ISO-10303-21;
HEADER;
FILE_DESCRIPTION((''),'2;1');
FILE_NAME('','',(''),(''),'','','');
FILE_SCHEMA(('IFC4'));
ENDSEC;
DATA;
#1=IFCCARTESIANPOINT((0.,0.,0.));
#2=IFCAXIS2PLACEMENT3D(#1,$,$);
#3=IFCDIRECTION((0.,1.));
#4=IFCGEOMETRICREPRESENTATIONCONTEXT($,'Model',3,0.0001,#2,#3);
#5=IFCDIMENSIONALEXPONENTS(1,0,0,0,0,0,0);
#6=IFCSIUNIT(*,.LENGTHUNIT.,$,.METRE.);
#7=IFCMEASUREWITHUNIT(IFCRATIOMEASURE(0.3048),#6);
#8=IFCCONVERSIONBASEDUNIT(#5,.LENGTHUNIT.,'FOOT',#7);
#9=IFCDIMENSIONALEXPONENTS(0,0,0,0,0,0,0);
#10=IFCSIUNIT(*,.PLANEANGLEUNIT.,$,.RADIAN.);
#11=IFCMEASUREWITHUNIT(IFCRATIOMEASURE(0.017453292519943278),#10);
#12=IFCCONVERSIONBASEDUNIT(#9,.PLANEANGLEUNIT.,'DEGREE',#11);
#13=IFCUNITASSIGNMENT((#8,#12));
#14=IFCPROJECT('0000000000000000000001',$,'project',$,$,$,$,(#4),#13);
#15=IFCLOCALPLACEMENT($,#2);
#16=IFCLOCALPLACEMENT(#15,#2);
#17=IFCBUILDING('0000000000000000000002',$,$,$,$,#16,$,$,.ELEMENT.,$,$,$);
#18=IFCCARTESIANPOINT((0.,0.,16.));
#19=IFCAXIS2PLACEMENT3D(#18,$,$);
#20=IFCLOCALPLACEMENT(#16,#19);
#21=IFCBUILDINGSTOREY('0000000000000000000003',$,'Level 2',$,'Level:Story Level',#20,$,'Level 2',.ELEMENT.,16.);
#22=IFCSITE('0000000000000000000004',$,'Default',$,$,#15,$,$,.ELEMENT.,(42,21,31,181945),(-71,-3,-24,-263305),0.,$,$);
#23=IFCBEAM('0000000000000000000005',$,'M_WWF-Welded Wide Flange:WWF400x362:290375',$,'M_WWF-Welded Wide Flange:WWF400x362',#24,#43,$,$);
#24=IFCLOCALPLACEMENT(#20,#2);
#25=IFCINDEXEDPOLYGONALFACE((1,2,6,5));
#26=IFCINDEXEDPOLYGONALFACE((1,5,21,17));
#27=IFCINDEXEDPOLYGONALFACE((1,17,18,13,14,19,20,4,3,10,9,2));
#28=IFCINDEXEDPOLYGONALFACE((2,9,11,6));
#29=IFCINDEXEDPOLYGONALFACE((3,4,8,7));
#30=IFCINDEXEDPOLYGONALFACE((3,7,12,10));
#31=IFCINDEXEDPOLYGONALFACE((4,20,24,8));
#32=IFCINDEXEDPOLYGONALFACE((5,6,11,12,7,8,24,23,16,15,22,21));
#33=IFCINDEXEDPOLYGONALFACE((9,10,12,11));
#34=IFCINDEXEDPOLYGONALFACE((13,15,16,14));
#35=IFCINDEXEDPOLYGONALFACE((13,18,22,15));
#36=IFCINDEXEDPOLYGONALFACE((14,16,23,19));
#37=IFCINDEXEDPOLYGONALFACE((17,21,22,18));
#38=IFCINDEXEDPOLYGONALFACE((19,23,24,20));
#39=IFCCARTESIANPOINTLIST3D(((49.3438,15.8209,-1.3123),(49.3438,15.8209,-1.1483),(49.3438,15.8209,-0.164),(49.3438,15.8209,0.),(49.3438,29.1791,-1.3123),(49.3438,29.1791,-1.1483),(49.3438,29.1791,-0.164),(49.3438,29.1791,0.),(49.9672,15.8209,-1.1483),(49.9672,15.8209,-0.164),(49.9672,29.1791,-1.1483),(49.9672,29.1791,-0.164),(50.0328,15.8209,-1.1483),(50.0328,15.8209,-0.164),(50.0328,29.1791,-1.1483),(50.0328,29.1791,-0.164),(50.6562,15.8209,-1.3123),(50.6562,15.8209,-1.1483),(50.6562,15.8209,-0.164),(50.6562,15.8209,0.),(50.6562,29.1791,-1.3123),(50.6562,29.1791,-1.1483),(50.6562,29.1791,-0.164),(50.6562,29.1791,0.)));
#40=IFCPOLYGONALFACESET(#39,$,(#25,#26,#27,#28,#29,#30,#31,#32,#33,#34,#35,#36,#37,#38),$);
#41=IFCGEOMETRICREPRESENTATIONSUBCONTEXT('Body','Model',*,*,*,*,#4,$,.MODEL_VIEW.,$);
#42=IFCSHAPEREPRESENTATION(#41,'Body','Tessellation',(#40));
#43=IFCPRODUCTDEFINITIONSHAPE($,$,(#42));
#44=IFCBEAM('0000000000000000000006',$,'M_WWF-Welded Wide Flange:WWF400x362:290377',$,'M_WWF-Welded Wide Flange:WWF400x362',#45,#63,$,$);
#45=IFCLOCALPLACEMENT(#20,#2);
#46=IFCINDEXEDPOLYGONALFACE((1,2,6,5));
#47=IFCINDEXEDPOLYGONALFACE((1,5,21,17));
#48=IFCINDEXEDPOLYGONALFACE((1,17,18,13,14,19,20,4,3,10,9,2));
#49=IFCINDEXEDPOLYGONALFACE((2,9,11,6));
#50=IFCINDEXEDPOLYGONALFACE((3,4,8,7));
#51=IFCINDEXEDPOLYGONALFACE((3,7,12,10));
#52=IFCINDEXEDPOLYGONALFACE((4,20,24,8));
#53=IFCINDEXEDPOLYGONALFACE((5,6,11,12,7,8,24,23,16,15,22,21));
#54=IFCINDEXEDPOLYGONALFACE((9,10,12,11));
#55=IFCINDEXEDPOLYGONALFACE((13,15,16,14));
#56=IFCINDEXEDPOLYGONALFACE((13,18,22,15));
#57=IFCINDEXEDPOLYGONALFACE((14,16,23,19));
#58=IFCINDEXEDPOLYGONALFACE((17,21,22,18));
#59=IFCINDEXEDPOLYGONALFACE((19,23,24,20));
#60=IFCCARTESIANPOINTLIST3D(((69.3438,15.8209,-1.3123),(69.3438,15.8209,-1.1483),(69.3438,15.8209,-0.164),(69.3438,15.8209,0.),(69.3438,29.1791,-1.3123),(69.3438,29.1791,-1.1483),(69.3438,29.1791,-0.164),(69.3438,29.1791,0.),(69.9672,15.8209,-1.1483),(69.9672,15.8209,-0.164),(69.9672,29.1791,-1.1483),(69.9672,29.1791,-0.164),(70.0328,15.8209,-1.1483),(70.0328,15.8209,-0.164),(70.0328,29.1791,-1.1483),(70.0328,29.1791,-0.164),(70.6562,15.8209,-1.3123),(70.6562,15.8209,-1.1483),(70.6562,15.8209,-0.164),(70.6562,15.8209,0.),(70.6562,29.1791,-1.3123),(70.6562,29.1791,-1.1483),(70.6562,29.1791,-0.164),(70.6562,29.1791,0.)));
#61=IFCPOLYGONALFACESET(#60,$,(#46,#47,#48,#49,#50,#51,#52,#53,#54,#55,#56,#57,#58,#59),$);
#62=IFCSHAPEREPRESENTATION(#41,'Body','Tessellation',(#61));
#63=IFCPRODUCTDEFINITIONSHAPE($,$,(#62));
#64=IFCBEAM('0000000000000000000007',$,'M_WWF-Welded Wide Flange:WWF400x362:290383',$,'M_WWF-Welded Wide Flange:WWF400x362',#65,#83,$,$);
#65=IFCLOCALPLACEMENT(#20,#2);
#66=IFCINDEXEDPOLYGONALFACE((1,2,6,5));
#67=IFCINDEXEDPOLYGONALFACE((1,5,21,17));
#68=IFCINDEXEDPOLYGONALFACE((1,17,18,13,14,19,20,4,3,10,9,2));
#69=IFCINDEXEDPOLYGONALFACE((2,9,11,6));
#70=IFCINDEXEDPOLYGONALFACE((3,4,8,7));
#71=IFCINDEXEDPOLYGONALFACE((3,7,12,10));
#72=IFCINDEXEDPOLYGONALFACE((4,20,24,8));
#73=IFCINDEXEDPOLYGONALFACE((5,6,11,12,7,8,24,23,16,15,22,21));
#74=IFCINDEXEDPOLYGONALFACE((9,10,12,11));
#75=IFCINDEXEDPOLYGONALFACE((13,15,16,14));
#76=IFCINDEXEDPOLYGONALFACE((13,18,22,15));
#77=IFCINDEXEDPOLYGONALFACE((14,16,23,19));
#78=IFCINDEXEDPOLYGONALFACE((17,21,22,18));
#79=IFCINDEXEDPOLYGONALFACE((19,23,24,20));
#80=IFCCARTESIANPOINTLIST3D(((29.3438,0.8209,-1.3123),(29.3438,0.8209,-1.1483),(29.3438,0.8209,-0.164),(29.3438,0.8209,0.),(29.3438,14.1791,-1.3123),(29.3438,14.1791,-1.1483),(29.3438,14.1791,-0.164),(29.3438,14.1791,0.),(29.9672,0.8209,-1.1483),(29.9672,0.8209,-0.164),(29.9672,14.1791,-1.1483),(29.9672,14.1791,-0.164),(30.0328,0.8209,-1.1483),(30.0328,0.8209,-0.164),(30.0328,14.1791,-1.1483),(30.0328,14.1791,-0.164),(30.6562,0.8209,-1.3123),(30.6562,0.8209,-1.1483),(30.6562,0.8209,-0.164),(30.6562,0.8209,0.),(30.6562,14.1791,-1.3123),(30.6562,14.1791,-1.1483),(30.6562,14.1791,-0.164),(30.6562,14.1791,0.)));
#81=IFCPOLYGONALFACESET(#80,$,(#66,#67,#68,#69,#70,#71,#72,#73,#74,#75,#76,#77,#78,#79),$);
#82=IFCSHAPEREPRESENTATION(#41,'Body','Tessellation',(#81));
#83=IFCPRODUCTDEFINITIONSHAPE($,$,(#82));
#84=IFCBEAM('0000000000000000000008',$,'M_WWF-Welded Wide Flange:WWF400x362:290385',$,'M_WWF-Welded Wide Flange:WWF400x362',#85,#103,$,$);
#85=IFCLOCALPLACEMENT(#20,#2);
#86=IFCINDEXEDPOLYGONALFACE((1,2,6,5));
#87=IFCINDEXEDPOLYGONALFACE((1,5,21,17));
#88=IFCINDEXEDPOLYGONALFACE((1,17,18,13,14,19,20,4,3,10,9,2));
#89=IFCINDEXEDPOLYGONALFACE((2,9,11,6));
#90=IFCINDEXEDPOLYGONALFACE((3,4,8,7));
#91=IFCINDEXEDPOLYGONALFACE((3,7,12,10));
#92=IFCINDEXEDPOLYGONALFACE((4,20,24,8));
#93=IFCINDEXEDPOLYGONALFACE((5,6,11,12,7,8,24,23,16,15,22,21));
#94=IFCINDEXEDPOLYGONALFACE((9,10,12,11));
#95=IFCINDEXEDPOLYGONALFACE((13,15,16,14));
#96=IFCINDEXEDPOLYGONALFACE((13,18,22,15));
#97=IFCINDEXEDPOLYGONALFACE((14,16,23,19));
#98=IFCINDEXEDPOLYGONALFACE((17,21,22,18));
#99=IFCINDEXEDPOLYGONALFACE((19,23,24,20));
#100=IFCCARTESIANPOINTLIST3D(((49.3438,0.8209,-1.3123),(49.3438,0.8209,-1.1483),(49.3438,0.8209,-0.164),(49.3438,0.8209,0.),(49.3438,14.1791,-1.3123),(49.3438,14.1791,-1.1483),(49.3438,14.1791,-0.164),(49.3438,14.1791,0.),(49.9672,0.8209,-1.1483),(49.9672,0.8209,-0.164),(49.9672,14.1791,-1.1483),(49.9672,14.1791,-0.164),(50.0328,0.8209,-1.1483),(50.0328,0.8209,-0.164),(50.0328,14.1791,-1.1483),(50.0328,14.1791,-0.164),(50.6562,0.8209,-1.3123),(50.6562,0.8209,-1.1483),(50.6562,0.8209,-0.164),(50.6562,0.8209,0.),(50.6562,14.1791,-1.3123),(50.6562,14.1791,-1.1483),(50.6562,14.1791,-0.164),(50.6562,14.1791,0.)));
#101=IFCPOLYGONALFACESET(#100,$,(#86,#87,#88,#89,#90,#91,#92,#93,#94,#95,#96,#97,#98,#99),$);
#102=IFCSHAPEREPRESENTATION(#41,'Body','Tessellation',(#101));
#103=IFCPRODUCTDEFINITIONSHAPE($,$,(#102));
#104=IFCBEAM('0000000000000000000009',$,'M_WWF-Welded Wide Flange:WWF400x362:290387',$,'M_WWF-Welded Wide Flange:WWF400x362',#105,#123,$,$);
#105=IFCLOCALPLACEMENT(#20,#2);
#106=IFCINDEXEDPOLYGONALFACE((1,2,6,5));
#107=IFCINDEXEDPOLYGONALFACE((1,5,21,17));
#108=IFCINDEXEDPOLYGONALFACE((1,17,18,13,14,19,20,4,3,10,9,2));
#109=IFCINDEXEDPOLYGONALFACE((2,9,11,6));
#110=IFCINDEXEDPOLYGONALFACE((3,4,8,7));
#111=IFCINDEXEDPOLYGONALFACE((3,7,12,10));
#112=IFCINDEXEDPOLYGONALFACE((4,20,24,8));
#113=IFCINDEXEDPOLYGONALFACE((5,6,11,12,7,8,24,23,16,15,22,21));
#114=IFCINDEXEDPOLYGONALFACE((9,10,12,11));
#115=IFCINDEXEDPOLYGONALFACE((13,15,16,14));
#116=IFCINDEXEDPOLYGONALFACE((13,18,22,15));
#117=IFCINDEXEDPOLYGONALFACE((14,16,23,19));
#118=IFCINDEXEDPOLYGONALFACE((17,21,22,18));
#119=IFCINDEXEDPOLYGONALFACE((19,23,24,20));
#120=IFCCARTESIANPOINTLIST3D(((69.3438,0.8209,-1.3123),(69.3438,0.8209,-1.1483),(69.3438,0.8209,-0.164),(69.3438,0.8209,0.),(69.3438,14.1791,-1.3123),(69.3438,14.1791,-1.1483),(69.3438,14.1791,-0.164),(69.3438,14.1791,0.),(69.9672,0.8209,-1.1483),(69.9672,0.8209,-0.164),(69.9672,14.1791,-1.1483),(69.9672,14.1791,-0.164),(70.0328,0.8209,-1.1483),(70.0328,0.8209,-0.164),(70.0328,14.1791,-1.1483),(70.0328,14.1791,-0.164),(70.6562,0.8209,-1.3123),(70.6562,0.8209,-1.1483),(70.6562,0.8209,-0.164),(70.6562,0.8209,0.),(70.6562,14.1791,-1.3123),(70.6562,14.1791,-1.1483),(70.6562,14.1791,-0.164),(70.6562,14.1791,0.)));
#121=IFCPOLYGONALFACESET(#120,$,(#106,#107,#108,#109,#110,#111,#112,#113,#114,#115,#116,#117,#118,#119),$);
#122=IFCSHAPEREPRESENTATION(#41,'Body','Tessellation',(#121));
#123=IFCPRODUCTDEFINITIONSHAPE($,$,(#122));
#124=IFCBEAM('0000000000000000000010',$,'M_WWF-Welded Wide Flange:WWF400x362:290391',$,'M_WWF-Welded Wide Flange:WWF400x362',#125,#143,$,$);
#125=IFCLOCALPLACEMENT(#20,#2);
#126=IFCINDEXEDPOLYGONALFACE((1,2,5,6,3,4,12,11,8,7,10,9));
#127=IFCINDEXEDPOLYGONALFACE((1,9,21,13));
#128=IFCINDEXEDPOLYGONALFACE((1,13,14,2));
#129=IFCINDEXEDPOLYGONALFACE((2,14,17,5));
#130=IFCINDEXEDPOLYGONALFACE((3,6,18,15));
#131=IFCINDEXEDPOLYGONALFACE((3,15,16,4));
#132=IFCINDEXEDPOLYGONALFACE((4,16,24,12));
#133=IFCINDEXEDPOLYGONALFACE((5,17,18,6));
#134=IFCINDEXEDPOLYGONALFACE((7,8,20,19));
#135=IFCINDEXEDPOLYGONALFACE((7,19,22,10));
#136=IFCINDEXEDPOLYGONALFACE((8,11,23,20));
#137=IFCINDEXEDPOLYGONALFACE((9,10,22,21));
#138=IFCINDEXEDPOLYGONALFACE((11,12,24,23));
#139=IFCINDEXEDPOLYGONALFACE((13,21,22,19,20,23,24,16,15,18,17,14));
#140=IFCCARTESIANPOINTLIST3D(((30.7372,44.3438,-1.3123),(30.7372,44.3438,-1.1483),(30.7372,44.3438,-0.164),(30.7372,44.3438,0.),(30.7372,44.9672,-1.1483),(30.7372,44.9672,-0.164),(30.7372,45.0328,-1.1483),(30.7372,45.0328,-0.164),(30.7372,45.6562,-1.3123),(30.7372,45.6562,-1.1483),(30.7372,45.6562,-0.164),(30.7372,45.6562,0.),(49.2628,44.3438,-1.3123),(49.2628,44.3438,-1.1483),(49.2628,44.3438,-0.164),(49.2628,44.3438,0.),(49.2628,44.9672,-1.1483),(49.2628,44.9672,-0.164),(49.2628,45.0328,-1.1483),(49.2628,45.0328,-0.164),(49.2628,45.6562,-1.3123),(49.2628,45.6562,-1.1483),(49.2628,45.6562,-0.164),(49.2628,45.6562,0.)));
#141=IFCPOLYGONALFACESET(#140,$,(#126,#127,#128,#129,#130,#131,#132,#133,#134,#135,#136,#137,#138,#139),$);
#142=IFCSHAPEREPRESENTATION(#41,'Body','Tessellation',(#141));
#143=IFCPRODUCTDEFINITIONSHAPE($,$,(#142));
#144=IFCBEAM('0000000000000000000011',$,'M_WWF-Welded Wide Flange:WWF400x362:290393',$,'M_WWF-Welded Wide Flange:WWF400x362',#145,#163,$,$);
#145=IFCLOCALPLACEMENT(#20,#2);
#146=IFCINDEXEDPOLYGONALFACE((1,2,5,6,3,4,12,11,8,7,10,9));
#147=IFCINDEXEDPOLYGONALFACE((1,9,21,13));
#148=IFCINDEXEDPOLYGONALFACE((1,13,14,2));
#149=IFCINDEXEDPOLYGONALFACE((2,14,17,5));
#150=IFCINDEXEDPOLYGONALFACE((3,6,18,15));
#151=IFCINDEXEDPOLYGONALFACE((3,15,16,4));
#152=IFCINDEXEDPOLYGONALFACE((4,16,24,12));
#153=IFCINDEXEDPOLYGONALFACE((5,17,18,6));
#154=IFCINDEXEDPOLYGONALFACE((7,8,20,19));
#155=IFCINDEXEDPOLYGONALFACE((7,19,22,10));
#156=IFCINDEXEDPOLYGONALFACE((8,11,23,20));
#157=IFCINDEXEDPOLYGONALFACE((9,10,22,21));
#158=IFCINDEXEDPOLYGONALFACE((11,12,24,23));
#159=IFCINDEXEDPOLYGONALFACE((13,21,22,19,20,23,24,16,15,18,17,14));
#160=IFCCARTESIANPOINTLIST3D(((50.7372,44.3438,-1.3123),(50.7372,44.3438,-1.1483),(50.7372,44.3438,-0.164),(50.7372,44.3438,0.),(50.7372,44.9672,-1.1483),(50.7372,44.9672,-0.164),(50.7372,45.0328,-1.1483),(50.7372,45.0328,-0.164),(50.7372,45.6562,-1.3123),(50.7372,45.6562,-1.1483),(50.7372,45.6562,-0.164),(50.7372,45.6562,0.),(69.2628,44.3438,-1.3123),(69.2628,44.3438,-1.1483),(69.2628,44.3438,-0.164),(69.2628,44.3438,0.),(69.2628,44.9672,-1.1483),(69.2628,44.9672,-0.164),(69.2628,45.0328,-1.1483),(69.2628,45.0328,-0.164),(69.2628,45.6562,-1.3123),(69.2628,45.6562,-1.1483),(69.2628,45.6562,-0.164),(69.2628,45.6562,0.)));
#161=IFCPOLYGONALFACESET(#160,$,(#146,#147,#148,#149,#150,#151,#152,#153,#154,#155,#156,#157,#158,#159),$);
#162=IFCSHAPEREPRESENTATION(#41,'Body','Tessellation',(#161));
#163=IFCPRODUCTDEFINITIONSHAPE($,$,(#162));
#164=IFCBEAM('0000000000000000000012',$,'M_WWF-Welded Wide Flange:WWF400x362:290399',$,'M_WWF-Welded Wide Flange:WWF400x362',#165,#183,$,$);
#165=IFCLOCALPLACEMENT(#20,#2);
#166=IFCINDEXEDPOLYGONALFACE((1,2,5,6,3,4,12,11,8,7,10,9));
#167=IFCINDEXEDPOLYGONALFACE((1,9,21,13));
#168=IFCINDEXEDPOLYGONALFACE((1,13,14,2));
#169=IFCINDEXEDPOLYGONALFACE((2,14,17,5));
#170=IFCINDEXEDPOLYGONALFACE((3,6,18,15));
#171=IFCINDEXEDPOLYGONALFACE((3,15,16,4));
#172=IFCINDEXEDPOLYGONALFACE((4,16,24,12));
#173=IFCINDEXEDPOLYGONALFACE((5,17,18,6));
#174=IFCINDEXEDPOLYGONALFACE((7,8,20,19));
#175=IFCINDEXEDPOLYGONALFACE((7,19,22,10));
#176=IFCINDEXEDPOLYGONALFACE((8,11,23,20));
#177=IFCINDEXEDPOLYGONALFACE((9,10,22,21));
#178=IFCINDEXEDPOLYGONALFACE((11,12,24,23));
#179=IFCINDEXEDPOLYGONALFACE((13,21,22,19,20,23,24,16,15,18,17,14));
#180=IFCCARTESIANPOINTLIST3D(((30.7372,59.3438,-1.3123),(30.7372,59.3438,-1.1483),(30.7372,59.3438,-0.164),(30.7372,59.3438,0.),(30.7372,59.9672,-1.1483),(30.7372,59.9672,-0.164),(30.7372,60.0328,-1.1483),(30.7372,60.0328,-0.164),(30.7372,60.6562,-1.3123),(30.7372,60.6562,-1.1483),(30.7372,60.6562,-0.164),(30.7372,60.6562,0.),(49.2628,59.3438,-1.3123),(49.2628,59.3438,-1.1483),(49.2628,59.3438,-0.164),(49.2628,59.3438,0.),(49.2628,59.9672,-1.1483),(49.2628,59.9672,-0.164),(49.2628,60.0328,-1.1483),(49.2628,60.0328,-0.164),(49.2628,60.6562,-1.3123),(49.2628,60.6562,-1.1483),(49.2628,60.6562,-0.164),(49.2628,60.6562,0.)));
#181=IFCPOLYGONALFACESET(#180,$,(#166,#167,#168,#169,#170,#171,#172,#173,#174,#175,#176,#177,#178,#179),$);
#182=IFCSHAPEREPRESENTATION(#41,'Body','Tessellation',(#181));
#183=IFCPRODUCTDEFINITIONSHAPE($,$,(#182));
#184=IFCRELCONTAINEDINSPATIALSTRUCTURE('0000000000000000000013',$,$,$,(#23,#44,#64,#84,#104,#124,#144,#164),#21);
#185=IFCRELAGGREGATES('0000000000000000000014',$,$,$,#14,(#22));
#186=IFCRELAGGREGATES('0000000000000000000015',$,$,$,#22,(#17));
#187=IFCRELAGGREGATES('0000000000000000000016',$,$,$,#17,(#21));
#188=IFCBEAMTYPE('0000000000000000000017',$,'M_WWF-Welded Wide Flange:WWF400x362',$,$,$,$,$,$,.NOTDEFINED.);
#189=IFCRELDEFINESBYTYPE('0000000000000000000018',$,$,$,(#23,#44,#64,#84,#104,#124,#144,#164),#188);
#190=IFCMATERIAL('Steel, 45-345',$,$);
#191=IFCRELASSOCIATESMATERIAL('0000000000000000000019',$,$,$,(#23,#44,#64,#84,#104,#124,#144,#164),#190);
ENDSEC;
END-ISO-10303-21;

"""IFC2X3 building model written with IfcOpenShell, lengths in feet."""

from ifc_helpers import new_model, entity, si_unit, converted_unit, direction, frame, frame_2d, origin, place, context, subcontext, project, spatial, i_section, extrude, material, type_object, element, save


model = new_model("IFC2X3")

# Units and contexts
model_context = context("Model", 3, precision=0.0001, world=origin(), true_north=direction((0.0, 1.0)))
body_context = subcontext(model_context, "Body", "Model", "MODEL_VIEW")
ifc_project = project(units=[converted_unit("LENGTHUNIT", "FOOT", entity("IfcRatioMeasure", 0.3048), si_unit("LENGTHUNIT", "METRE"), dimensions=[1, 0, 0, 0, 0, 0, 0]), converted_unit("PLANEANGLEUNIT", "DEGREE", entity("IfcRatioMeasure", 0.017453292519943278), si_unit("PLANEANGLEUNIT", "RADIAN"), dimensions=[0, 0, 0, 0, 0, 0, 0])], contexts=[model_context])

# Site, building, storey
site_placement = place(None, origin())
site = spatial("IfcSite", under=ifc_project, at=site_placement, Name="Default", CompositionType="ELEMENT", RefLatitude=(42, 21, 31, 181945), RefLongitude=(-71, -3, -24, -263305), RefElevation=0.0)
building_placement = place(site_placement, origin())
building = spatial("IfcBuilding", under=site, at=building_placement, CompositionType="ELEMENT")
storey_placement = place(building_placement, frame((0.0, 0.0, 16.0)))
storey = spatial("IfcBuildingStorey", under=building, at=storey_placement, Name="Level 2", ObjectType="Level:Story Level", LongName="Level 2", CompositionType="ELEMENT", Elevation=16.0)

# Shared definitions
ifc_material = material(Name="Steel, 45-345")

# Beams
beam_type = type_object("IfcBeamType", Name="M_WWF-Welded Wide Flange:WWF400x362", PredefinedType="NOTDEFINED")
beam_1_placement = place(storey_placement, frame((50.0, 15.0, 0.0), z_axis=(0.0, 0.0, 1.0), x_axis=(0.0, 1.0, 0.0)))
element("IfcBeam", 1, at=beam_1_placement, inside=storey, type_object=beam_type, material=ifc_material, Name="M_WWF-Welded Wide Flange:WWF400x362:290375", ObjectType="M_WWF-Welded Wide Flange:WWF400x362", context=body_context, shape_type="SweptSolid", body=[
    extrude(i_section(OverallWidth=1.3123, OverallDepth=1.3123, WebThickness=0.0656, FlangeThickness=0.164, at=frame_2d((0.0, 0.0), x_axis=(0.0, 1.0))), frame((0.8209, 0.0, -0.6562), z_axis=(1.0, 0.0, 0.0), x_axis=(0.0, 0.0, -1.0)), (0.0, 0.0, 1.0), 13.3583),
])
beam_2_placement = place(storey_placement, frame((70.0, 15.0, 0.0), z_axis=(0.0, 0.0, 1.0), x_axis=(0.0, 1.0, 0.0)))
element("IfcBeam", 2, at=beam_2_placement, inside=storey, type_object=beam_type, material=ifc_material, Name="M_WWF-Welded Wide Flange:WWF400x362:290377", ObjectType="M_WWF-Welded Wide Flange:WWF400x362", context=body_context, shape_type="SweptSolid", body=[
    extrude(i_section(OverallWidth=1.3123, OverallDepth=1.3123, WebThickness=0.0656, FlangeThickness=0.164, at=frame_2d((0.0, 0.0), x_axis=(0.0, 1.0))), frame((0.8209, 0.0, -0.6562), z_axis=(1.0, 0.0, 0.0), x_axis=(0.0, 0.0, -1.0)), (0.0, 0.0, 1.0), 13.3583),
])
beam_3_placement = place(storey_placement, frame((30.0, 0.0, 0.0), z_axis=(0.0, 0.0, 1.0), x_axis=(0.0, 1.0, 0.0)))
element("IfcBeam", 3, at=beam_3_placement, inside=storey, type_object=beam_type, material=ifc_material, Name="M_WWF-Welded Wide Flange:WWF400x362:290383", ObjectType="M_WWF-Welded Wide Flange:WWF400x362", context=body_context, shape_type="SweptSolid", body=[
    extrude(i_section(OverallWidth=1.3123, OverallDepth=1.3123, WebThickness=0.0656, FlangeThickness=0.164, at=frame_2d((0.0, 0.0), x_axis=(0.0, 1.0))), frame((0.8209, 0.0, -0.6562), z_axis=(1.0, 0.0, 0.0), x_axis=(0.0, 0.0, -1.0)), (0.0, 0.0, 1.0), 13.3583),
])
beam_4_placement = place(storey_placement, frame((50.0, 0.0, 0.0), z_axis=(0.0, 0.0, 1.0), x_axis=(0.0, 1.0, 0.0)))
element("IfcBeam", 4, at=beam_4_placement, inside=storey, type_object=beam_type, material=ifc_material, Name="M_WWF-Welded Wide Flange:WWF400x362:290385", ObjectType="M_WWF-Welded Wide Flange:WWF400x362", context=body_context, shape_type="SweptSolid", body=[
    extrude(i_section(OverallWidth=1.3123, OverallDepth=1.3123, WebThickness=0.0656, FlangeThickness=0.164, at=frame_2d((0.0, 0.0), x_axis=(0.0, 1.0))), frame((0.8209, 0.0, -0.6562), z_axis=(1.0, 0.0, 0.0), x_axis=(0.0, 0.0, -1.0)), (0.0, 0.0, 1.0), 13.3583),
])
beam_5_placement = place(storey_placement, frame((70.0, 0.0, 0.0), z_axis=(0.0, 0.0, 1.0), x_axis=(0.0, 1.0, 0.0)))
element("IfcBeam", 5, at=beam_5_placement, inside=storey, type_object=beam_type, material=ifc_material, Name="M_WWF-Welded Wide Flange:WWF400x362:290387", ObjectType="M_WWF-Welded Wide Flange:WWF400x362", context=body_context, shape_type="SweptSolid", body=[
    extrude(i_section(OverallWidth=1.3123, OverallDepth=1.3123, WebThickness=0.0656, FlangeThickness=0.164, at=frame_2d((0.0, 0.0), x_axis=(0.0, 1.0))), frame((0.8209, 0.0, -0.6562), z_axis=(1.0, 0.0, 0.0), x_axis=(0.0, 0.0, -1.0)), (0.0, 0.0, 1.0), 13.3583),
])
beam_6_placement = place(storey_placement, frame((30.0, 45.0, 0.0)))
element("IfcBeam", 6, at=beam_6_placement, inside=storey, type_object=beam_type, material=ifc_material, Name="M_WWF-Welded Wide Flange:WWF400x362:290391", ObjectType="M_WWF-Welded Wide Flange:WWF400x362", context=body_context, shape_type="SweptSolid", body=[
    extrude(i_section(OverallWidth=1.3123, OverallDepth=1.3123, WebThickness=0.0656, FlangeThickness=0.164, at=frame_2d((0.0, 0.0), x_axis=(0.0, 1.0))), frame((0.7372, 0.0, -0.6562), z_axis=(1.0, 0.0, 0.0), x_axis=(0.0, 0.0, -1.0)), (0.0, 0.0, 1.0), 18.5256),
])
beam_7_placement = place(storey_placement, frame((50.0, 45.0, 0.0)))
element("IfcBeam", 7, at=beam_7_placement, inside=storey, type_object=beam_type, material=ifc_material, Name="M_WWF-Welded Wide Flange:WWF400x362:290393", ObjectType="M_WWF-Welded Wide Flange:WWF400x362", context=body_context, shape_type="SweptSolid", body=[
    extrude(i_section(OverallWidth=1.3123, OverallDepth=1.3123, WebThickness=0.0656, FlangeThickness=0.164, at=frame_2d((0.0, 0.0), x_axis=(0.0, 1.0))), frame((0.7372, 0.0, -0.6562), z_axis=(1.0, 0.0, 0.0), x_axis=(0.0, 0.0, -1.0)), (0.0, 0.0, 1.0), 18.5256),
])
beam_8_placement = place(storey_placement, frame((30.0, 60.0, 0.0)))
element("IfcBeam", 8, at=beam_8_placement, inside=storey, type_object=beam_type, material=ifc_material, Name="M_WWF-Welded Wide Flange:WWF400x362:290399", ObjectType="M_WWF-Welded Wide Flange:WWF400x362", context=body_context, shape_type="SweptSolid", body=[
    extrude(i_section(OverallWidth=1.3123, OverallDepth=1.3123, WebThickness=0.0656, FlangeThickness=0.164, at=frame_2d((0.0, 0.0), x_axis=(0.0, 1.0))), frame((0.7372, 0.0, -0.6562), z_axis=(1.0, 0.0, 0.0), x_axis=(0.0, 0.0, -1.0)), (0.0, 0.0, 1.0), 18.5256),
])

save(model, "model.ifc")
